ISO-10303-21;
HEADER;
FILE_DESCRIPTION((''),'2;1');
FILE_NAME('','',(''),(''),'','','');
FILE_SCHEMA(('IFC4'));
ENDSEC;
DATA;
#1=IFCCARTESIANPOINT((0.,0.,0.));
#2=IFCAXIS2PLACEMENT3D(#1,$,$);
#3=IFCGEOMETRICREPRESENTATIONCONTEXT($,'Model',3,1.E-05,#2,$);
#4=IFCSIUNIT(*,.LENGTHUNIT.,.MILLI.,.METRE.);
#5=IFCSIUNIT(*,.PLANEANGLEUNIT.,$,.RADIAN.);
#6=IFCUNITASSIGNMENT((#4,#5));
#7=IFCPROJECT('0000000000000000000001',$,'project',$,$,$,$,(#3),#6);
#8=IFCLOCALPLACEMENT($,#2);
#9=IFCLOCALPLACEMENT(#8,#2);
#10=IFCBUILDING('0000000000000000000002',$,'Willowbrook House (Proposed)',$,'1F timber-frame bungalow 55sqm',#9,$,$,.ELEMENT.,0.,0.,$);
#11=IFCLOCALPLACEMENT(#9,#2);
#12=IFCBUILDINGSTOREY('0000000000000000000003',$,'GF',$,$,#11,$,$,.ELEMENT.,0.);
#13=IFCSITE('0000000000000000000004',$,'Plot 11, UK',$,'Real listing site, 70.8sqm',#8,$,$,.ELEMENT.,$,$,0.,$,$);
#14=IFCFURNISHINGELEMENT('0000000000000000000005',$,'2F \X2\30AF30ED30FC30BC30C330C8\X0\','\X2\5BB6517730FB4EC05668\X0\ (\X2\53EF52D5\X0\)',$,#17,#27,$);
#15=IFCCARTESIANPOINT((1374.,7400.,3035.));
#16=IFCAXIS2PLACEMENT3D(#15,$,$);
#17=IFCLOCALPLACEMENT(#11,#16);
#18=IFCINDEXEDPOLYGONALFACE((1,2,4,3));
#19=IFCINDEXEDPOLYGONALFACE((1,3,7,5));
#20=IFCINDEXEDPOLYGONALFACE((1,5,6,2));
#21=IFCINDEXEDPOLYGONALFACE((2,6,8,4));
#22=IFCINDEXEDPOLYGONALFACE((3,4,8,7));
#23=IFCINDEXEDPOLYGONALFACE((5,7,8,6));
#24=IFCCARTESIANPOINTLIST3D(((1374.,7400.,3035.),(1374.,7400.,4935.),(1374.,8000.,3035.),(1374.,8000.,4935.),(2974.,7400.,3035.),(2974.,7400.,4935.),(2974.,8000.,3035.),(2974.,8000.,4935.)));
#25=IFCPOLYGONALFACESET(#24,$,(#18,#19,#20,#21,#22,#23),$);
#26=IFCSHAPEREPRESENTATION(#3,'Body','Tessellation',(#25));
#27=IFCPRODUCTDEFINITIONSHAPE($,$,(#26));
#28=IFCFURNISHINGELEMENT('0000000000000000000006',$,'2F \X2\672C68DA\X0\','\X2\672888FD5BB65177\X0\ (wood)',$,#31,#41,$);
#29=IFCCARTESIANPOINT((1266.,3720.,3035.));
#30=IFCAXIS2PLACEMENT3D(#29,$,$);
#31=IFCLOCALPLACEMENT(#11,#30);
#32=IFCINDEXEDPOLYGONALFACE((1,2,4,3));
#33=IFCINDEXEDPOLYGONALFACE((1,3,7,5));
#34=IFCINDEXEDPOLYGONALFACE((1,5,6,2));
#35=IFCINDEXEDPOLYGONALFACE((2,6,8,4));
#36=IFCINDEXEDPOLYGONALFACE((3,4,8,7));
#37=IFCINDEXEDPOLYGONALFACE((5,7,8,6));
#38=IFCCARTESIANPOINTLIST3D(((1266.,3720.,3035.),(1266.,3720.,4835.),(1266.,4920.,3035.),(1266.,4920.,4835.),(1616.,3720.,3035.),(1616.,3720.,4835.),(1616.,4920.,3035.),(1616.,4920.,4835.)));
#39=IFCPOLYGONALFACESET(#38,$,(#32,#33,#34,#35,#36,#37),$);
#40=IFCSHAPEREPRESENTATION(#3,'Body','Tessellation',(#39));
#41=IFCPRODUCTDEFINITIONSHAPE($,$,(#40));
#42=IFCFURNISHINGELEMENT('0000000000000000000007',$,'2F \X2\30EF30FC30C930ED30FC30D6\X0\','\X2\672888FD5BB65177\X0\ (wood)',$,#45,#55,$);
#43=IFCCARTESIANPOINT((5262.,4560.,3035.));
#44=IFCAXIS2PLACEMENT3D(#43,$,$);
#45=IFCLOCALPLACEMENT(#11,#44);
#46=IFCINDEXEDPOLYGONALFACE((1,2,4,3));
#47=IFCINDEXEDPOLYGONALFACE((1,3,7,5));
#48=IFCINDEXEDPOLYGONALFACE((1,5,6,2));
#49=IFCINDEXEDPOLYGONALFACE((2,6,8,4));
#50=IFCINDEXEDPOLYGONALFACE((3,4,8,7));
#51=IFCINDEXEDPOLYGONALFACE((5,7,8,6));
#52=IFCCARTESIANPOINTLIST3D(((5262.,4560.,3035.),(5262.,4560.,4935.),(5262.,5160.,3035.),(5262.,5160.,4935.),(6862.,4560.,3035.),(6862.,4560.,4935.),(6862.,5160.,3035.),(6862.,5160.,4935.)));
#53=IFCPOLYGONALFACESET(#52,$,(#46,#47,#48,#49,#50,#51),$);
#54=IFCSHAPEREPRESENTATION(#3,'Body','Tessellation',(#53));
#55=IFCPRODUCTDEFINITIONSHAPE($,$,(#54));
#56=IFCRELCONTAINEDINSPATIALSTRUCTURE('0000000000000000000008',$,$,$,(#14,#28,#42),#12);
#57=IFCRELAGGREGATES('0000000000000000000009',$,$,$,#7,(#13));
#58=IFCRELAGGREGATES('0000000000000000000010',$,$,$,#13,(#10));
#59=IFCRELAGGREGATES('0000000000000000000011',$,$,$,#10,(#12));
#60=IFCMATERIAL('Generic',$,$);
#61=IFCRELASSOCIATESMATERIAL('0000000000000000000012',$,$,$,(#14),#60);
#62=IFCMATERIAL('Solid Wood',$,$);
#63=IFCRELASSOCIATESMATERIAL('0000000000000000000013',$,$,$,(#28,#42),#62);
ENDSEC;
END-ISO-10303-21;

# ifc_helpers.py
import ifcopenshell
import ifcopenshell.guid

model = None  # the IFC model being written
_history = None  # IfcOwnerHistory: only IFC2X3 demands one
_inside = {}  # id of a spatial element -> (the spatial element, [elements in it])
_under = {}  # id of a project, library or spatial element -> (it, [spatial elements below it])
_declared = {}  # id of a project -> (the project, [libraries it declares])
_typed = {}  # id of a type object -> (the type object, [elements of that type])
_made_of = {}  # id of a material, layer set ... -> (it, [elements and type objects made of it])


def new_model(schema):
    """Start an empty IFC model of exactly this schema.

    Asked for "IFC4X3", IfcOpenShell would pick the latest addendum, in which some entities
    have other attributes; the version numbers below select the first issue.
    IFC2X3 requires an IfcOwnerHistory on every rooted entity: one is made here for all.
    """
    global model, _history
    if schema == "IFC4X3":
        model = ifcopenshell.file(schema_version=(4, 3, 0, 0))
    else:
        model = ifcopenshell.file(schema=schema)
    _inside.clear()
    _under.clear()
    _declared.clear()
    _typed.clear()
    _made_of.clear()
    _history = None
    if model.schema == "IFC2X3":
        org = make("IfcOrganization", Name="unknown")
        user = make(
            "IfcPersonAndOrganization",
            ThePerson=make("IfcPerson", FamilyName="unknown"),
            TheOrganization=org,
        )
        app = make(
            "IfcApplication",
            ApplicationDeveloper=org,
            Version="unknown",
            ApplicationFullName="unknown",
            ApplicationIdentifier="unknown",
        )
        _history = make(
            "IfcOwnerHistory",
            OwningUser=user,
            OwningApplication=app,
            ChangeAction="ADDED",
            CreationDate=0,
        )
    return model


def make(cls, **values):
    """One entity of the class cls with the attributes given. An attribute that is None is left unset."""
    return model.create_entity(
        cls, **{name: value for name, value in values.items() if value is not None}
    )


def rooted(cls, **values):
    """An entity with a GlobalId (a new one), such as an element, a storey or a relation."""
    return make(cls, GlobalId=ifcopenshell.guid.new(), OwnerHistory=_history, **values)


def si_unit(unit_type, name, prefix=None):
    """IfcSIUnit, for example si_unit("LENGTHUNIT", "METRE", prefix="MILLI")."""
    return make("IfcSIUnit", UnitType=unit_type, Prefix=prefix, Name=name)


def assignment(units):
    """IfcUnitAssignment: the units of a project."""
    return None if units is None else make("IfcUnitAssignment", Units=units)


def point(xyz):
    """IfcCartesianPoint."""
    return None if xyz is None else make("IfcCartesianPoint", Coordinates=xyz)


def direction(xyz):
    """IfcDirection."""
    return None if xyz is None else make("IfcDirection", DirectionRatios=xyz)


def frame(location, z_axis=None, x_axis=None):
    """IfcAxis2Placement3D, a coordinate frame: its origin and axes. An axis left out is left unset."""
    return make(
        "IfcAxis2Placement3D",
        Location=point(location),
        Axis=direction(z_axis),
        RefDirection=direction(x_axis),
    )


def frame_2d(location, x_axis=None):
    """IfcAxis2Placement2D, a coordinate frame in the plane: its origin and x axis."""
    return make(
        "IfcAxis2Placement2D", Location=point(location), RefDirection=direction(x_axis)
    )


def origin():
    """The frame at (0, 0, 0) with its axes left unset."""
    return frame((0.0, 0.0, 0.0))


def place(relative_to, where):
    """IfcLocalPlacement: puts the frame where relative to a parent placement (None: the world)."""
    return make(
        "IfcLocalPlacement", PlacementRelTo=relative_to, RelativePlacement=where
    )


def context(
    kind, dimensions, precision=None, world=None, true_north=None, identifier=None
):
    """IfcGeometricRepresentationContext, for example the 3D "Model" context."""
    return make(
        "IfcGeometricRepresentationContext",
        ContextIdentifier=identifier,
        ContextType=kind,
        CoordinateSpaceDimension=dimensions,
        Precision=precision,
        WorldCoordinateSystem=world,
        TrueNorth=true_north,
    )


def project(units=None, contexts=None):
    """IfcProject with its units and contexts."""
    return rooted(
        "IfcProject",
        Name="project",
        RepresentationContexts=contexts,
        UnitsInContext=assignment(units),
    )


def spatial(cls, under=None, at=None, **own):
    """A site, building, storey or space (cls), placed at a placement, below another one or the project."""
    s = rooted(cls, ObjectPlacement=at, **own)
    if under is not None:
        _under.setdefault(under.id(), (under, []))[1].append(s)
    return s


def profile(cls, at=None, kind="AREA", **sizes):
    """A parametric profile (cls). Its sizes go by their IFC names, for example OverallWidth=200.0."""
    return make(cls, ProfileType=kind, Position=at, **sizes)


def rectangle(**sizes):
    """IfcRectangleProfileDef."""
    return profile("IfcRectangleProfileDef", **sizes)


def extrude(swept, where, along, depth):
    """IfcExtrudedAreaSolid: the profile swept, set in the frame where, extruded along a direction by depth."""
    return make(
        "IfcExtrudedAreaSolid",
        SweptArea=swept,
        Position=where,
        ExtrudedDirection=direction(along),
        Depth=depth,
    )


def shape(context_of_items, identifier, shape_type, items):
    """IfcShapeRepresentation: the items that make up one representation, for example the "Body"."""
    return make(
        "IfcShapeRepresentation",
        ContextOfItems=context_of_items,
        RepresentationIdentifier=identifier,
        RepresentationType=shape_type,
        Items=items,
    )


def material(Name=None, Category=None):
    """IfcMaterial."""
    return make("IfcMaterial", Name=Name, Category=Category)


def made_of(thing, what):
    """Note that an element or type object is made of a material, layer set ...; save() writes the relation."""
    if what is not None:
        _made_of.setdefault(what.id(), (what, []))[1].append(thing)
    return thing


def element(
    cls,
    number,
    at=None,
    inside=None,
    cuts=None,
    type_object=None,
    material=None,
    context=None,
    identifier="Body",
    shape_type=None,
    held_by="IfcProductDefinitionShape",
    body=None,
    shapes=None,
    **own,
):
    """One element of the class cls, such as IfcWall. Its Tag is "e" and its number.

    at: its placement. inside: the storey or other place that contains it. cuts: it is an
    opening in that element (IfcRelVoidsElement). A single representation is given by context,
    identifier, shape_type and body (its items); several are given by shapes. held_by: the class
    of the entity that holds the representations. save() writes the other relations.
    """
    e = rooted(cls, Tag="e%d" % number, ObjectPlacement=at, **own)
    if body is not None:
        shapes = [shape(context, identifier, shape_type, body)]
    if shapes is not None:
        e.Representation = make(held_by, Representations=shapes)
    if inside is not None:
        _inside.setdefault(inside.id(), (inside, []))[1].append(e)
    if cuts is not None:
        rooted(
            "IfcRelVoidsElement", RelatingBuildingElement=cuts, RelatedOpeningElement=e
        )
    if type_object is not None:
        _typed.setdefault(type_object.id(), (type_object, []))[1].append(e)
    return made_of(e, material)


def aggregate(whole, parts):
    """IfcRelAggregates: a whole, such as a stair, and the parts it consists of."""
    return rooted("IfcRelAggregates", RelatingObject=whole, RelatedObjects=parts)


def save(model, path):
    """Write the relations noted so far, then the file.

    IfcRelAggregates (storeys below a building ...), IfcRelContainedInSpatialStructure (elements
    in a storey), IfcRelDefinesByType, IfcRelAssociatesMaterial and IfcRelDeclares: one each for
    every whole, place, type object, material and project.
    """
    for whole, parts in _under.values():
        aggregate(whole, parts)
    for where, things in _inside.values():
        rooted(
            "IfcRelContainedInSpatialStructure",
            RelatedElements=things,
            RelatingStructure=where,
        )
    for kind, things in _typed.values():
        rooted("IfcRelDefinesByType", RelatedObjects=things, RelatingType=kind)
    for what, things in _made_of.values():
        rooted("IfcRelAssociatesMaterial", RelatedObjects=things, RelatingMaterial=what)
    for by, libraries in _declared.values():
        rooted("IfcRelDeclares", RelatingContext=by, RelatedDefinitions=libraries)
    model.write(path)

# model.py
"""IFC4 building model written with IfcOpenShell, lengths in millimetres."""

from ifc_helpers import new_model, si_unit, frame, frame_2d, origin, place, context, project, spatial, rectangle, extrude, material, element, save


model = new_model("IFC4")

# Units and contexts
model_context = context("Model", 3, precision=1e-05, world=origin())
ifc_project = project(units=[si_unit("LENGTHUNIT", "METRE", prefix="MILLI"), si_unit("PLANEANGLEUNIT", "RADIAN")], contexts=[model_context])

# Site, building, storey
site_placement = place(None, origin())
site = spatial("IfcSite", under=ifc_project, at=site_placement, Name="Plot 11, UK", ObjectType="Real listing site, 70.8sqm", CompositionType="ELEMENT", RefElevation=0.0)
building_placement = place(site_placement, origin())
building = spatial("IfcBuilding", under=site, at=building_placement, Name="Willowbrook House (Proposed)", ObjectType="1F timber-frame bungalow 55sqm", CompositionType="ELEMENT", ElevationOfRefHeight=0.0, ElevationOfTerrain=0.0)
storey_placement = place(building_placement, origin())
storey = spatial("IfcBuildingStorey", under=building, at=storey_placement, Name="GF", CompositionType="ELEMENT", Elevation=0.0)

# Shared definitions
ifc_material_1 = material(Name="Solid Wood")

# Shared definitions
ifc_material_2 = material(Name="Generic")

# Furnishing elements
furnishing_1_placement = place(storey_placement, frame((1374.0, 7400.0, 3035.0)))
element("IfcFurnishingElement", 1, at=furnishing_1_placement, inside=storey, material=ifc_material_2, Name="2F クローゼット", Description="家具・什器 (可動)", context=model_context, shape_type="SweptSolid", body=[
    extrude(rectangle(XDim=1600.0, YDim=600.0, at=frame_2d((800.0, 300.0))), frame((1374.0, 7400.0, 3035.0)), (0.0, 0.0, 1.0), 1900.0),
])
furnishing_2_placement = place(storey_placement, frame((1266.0, 3720.0, 3035.0)))
element("IfcFurnishingElement", 2, at=furnishing_2_placement, inside=storey, material=ifc_material_1, Name="2F 本棚", Description="木製家具 (wood)", context=model_context, shape_type="SweptSolid", body=[
    extrude(rectangle(XDim=350.0, YDim=1200.0, at=frame_2d((175.0, 600.0))), frame((1266.0, 3720.0, 3035.0)), (0.0, 0.0, 1.0), 1800.0),
])
furnishing_3_placement = place(storey_placement, frame((5262.0, 4560.0, 3035.0)))
element("IfcFurnishingElement", 3, at=furnishing_3_placement, inside=storey, material=ifc_material_1, Name="2F ワードローブ", Description="木製家具 (wood)", context=model_context, shape_type="SweptSolid", body=[
    extrude(rectangle(XDim=1600.0, YDim=600.0, at=frame_2d((800.0, 300.0))), frame((5262.0, 4560.0, 3035.0)), (0.0, 0.0, 1.0), 1900.0),
])

save(model, "model.ifc")
